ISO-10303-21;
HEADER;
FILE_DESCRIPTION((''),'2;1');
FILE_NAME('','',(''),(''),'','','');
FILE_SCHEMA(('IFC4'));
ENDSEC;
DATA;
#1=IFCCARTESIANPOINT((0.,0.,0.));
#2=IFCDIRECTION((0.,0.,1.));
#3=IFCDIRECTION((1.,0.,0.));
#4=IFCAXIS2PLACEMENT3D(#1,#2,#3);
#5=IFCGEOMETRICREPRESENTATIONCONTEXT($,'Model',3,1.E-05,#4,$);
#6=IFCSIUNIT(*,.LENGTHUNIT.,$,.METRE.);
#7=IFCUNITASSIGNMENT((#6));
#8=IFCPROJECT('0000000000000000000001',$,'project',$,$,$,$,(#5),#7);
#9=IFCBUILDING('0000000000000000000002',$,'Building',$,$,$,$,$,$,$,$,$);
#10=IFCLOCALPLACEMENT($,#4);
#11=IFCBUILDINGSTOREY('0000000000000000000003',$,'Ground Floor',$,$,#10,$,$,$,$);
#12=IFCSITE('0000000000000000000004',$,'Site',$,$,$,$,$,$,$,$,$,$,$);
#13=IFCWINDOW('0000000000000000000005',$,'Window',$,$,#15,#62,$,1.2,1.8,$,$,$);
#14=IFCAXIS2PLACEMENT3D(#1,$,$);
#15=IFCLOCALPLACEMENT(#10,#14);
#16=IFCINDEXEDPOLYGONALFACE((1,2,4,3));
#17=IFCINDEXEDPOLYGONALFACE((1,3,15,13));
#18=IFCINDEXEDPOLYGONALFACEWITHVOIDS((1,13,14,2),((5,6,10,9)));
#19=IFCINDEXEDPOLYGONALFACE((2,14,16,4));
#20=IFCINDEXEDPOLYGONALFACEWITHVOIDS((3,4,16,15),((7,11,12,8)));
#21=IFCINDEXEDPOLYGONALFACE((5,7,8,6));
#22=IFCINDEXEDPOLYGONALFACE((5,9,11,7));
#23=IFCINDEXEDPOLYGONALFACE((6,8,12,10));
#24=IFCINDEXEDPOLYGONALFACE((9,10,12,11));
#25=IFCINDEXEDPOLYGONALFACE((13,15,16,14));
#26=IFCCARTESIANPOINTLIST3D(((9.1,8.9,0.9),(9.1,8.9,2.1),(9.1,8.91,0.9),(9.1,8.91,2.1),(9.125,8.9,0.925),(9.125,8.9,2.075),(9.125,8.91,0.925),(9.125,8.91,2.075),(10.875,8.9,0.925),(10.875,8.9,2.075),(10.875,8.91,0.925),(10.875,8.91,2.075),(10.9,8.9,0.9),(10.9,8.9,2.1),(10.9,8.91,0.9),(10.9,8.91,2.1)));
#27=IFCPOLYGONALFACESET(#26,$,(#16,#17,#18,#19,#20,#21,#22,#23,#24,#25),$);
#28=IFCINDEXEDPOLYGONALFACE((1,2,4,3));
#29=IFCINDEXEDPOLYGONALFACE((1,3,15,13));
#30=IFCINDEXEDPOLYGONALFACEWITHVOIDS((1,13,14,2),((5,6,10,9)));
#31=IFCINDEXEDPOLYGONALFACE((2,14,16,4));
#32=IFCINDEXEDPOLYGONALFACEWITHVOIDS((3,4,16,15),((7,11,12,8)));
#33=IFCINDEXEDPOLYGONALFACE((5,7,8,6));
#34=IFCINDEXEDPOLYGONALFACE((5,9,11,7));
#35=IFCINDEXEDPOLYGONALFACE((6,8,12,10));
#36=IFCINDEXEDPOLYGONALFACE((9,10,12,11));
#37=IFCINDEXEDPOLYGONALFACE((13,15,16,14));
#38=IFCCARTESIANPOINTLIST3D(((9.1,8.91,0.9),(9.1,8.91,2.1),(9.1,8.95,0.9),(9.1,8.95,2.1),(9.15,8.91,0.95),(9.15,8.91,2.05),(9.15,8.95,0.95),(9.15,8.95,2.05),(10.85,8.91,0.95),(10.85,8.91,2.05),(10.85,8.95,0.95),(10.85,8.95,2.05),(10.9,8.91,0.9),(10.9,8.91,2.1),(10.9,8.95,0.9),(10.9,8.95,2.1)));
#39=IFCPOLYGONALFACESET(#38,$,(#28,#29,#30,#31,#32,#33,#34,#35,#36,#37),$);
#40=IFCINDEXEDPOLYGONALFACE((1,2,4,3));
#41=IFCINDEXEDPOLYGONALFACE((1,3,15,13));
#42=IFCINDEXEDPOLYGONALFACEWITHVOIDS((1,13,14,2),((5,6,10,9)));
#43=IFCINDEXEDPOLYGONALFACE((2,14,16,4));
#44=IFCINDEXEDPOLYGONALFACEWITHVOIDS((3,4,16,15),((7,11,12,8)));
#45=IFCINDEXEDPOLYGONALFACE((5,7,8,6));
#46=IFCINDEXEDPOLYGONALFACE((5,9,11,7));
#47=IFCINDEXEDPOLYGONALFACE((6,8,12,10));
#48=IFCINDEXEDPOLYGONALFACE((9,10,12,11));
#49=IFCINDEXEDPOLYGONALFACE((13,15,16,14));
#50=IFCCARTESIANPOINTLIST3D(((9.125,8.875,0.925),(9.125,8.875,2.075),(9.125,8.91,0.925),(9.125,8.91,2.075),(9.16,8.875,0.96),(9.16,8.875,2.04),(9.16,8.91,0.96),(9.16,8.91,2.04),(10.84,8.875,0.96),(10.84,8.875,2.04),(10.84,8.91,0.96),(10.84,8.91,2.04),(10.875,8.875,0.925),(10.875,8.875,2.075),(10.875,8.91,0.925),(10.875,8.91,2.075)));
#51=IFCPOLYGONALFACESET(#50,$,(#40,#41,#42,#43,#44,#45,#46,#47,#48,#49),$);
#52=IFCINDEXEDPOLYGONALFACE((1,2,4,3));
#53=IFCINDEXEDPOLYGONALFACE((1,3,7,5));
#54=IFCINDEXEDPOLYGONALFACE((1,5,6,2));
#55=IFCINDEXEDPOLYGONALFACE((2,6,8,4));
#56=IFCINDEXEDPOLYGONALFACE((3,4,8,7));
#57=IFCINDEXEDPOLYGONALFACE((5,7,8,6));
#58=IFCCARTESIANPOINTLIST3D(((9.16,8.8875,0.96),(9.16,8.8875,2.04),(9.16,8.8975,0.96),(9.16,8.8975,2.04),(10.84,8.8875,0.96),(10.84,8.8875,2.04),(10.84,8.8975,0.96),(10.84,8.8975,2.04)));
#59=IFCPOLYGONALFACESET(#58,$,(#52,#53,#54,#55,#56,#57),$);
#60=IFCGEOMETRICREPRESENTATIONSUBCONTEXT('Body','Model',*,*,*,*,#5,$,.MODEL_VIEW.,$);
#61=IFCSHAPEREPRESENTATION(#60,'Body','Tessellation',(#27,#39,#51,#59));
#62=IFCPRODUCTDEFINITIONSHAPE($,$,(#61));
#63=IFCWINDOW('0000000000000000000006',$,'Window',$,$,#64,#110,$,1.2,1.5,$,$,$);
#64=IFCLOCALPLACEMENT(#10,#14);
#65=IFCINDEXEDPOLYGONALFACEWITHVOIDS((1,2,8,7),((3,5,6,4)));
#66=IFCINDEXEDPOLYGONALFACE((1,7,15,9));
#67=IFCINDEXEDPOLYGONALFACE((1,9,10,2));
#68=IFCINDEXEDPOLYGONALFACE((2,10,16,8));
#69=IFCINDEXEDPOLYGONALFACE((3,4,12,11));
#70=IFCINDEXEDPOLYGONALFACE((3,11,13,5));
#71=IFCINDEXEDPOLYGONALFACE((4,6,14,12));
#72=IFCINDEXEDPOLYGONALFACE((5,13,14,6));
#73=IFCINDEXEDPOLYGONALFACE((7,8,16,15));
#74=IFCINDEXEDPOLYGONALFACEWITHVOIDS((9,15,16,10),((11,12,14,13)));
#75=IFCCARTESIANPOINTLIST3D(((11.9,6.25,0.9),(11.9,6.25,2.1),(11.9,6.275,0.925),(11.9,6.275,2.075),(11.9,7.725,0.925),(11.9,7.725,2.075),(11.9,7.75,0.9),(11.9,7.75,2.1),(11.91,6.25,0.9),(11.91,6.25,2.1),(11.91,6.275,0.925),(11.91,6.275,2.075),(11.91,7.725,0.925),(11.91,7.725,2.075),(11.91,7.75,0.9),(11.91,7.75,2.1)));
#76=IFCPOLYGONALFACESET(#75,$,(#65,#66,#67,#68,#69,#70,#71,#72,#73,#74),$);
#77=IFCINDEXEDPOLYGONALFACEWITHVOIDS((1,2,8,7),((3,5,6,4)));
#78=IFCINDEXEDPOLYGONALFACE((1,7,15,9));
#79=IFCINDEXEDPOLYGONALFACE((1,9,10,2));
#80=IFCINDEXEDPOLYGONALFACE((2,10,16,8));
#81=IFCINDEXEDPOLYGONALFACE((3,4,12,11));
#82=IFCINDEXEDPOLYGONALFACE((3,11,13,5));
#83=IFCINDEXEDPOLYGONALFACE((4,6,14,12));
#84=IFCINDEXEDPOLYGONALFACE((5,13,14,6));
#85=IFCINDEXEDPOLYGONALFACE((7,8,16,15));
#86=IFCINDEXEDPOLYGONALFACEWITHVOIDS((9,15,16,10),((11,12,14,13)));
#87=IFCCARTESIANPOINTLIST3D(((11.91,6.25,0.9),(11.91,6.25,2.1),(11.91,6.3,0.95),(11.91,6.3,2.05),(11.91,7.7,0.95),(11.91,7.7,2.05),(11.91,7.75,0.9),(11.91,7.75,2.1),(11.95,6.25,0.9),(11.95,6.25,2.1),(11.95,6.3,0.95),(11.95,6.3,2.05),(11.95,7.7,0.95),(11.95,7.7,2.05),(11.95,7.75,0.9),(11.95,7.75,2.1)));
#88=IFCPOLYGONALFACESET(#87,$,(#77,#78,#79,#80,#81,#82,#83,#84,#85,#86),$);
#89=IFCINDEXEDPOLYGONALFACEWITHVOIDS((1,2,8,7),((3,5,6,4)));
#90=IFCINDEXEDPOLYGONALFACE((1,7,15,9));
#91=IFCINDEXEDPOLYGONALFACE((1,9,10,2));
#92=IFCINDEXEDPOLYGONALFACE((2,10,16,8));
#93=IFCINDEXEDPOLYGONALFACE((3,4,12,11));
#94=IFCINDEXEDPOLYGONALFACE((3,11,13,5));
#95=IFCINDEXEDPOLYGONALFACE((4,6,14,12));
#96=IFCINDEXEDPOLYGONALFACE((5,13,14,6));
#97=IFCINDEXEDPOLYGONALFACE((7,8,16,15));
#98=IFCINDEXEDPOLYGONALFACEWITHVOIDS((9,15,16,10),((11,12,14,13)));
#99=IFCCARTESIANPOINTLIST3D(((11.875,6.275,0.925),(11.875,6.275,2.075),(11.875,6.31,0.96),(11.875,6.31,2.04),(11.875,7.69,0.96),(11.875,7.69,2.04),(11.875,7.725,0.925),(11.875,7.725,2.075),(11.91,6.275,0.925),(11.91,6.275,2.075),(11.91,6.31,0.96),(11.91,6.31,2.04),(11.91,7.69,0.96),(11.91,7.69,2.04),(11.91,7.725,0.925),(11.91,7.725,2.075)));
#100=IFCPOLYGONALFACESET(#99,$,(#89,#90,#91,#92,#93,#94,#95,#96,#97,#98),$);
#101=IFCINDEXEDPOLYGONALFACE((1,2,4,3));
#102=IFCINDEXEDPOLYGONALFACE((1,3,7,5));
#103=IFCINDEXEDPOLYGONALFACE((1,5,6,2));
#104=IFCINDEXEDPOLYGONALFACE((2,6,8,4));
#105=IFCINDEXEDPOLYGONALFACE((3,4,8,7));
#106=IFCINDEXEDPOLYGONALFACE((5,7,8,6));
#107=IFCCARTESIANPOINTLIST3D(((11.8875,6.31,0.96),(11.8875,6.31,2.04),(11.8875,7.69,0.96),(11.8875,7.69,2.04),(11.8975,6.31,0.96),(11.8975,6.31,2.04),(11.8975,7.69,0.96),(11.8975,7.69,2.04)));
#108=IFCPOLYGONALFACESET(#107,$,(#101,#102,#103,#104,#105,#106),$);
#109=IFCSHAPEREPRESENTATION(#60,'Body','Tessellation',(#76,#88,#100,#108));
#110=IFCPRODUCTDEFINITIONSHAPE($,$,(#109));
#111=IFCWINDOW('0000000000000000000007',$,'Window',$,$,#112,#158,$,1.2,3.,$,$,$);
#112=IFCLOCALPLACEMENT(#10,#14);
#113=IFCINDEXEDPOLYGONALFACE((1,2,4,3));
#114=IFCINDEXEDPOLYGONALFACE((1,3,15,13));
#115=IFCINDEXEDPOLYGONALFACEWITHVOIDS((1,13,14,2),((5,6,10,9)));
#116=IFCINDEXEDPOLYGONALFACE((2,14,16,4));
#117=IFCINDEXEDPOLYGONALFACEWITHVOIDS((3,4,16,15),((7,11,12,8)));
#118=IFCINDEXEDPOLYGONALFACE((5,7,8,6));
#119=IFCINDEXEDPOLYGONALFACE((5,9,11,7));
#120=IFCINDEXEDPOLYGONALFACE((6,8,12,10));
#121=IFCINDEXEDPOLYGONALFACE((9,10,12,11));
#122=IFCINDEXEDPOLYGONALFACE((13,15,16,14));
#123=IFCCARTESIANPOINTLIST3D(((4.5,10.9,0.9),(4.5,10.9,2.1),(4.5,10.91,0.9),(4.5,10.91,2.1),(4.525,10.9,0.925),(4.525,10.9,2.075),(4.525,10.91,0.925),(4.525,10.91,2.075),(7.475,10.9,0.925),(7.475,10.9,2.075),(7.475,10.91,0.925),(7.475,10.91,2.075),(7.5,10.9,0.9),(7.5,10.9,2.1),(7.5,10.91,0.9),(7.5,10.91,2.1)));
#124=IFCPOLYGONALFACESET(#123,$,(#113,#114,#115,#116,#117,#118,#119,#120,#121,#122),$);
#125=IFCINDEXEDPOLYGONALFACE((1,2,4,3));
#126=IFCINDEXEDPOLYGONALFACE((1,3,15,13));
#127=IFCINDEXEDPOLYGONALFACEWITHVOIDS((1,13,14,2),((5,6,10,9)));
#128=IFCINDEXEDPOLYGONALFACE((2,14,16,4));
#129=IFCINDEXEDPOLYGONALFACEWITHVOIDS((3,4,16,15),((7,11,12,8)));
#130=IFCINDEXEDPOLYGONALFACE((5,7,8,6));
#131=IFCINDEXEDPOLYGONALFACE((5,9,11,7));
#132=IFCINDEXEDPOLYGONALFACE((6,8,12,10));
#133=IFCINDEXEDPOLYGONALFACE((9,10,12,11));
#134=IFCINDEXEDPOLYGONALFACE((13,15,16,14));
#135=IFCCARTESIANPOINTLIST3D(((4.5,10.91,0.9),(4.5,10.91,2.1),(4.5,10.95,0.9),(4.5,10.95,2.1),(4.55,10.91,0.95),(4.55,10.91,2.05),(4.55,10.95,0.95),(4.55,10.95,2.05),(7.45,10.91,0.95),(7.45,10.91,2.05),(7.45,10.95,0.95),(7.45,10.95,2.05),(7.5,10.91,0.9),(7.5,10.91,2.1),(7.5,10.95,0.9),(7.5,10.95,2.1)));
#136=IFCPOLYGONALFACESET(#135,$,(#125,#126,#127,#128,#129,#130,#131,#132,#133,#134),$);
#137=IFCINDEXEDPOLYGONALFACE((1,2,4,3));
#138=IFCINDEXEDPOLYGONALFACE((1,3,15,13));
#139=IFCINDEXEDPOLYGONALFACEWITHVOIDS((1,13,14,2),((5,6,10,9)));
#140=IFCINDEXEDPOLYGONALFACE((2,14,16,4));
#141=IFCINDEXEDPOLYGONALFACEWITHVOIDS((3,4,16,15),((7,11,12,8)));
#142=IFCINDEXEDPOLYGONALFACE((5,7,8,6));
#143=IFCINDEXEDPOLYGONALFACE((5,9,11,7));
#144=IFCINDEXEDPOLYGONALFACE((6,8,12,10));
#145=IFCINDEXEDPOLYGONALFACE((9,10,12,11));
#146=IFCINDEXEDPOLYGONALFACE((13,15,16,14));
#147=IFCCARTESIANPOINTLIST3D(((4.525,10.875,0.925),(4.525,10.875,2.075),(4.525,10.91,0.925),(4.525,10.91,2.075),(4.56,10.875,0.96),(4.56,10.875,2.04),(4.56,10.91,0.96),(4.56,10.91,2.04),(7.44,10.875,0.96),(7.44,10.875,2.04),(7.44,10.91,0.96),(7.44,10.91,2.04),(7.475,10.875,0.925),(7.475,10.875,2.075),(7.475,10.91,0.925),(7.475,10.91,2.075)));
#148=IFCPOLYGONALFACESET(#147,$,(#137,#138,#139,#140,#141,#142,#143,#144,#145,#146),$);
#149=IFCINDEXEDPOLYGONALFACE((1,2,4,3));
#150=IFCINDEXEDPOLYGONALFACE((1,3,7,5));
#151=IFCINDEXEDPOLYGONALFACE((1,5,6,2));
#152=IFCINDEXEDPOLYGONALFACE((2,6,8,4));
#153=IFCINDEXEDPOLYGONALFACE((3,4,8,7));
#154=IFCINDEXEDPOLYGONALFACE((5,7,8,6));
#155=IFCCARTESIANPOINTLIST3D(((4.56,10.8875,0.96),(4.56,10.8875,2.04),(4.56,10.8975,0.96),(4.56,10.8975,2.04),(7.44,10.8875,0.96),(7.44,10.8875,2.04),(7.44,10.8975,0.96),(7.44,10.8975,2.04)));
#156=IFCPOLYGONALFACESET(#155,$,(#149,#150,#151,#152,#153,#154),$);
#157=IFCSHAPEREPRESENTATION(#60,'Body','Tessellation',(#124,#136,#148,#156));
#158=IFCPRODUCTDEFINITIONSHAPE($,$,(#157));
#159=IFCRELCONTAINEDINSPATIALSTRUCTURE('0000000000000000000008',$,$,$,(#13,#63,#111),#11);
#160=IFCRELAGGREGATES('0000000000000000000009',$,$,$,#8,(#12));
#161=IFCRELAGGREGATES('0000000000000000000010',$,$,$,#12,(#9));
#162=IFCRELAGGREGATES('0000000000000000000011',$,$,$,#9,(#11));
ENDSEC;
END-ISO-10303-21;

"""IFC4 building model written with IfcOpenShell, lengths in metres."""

from ifc_helpers import new_model, si_unit, frame, origin_with_axes, place, context, subcontext, project, spatial, line, indexed_curve, outline, extrude, element, save


model = new_model("IFC4")

# Units and contexts
model_context = context("Model", 3, precision=1e-05, world=origin_with_axes())
body_context = subcontext(model_context, "Body", "Model", "MODEL_VIEW")
ifc_project = project(units=[si_unit("LENGTHUNIT", "METRE")], contexts=[model_context])

# Site, building, storey
site = spatial("IfcSite", under=ifc_project, Name="Site")
building = spatial("IfcBuilding", under=site, Name="Building")
storey_placement = place(None, origin_with_axes())
storey = spatial("IfcBuildingStorey", under=building, at=storey_placement, Name="Ground Floor")

# Windows
window_1_placement = place(storey_placement, frame((10.9, 9.0, 0.9), z_axis=(0.0, 0.0, 1.0), x_axis=(-1.0, 0.0, 0.0)))
element("IfcWindow", 1, at=window_1_placement, inside=storey, Name="Window", OverallHeight=1.2, OverallWidth=1.8, context=body_context, shape_type="SweptSolid", body=[
    extrude(outline(indexed_curve([(0.0, 0.0), (1.8, 0.0), (1.8, 1.2), (0.0, 1.2)], segments=[line(1, 2, 3, 4, 1)]), holes=[indexed_curve([(0.025, 0.025), (1.775, 0.025), (1.775, 1.175), (0.025, 1.175)], segments=[line(1, 2, 3, 4, 1)])]), frame((0.0, 0.09, 0.0), z_axis=(0.0, -1.0, 0.0), x_axis=(1.0, 0.0, 0.0)), (0.0, 0.0, -1.0), 0.01),
    extrude(outline(indexed_curve([(0.0, 0.0), (1.8, 0.0), (1.8, 1.2), (0.0, 1.2)], segments=[line(1, 2, 3, 4, 1)]), holes=[indexed_curve([(0.05, 0.05), (1.75, 0.05), (1.75, 1.15), (0.05, 1.15)], segments=[line(1, 2, 3, 4, 1)])]), frame((0.0, 0.05, 0.0), z_axis=(0.0, -1.0, 0.0), x_axis=(1.0, 0.0, 0.0)), (0.0, 0.0, -1.0), 0.04),
    extrude(outline(indexed_curve([(0.0, 0.0), (1.75, 0.0), (1.75, 1.15), (0.0, 1.15)], segments=[line(1, 2, 3, 4, 1)]), holes=[indexed_curve([(0.035, 0.035), (1.715, 0.035), (1.715, 1.115), (0.035, 1.115)], segments=[line(1, 2, 3, 4, 1)])]), frame((0.025, 0.09, 0.025), z_axis=(0.0, -1.0, 0.0), x_axis=(1.0, 0.0, 0.0)), (0.0, 0.0, -1.0), 0.035),
    extrude(outline(indexed_curve([(0.035, 0.035), (1.715, 0.035), (1.715, 1.115), (0.035, 1.115)], segments=[line(1, 2, 3, 4, 1)])), frame((0.025, 0.1025, 0.025), z_axis=(0.0, -1.0, 0.0), x_axis=(1.0, 0.0, 0.0)), (0.0, 0.0, -1.0), 0.01),
])
window_2_placement = place(storey_placement, frame((12.0, 6.25, 0.9), z_axis=(0.0, 0.0, 1.0), x_axis=(0.0, 1.0, 0.0)))
element("IfcWindow", 2, at=window_2_placement, inside=storey, Name="Window", OverallHeight=1.2, OverallWidth=1.5, context=body_context, shape_type="SweptSolid", body=[
    extrude(outline(indexed_curve([(0.0, 0.0), (1.5, 0.0), (1.5, 1.2), (0.0, 1.2)], segments=[line(1, 2, 3, 4, 1)]), holes=[indexed_curve([(0.025, 0.025), (1.475, 0.025), (1.475, 1.175), (0.025, 1.175)], segments=[line(1, 2, 3, 4, 1)])]), frame((0.0, 0.09, 0.0), z_axis=(0.0, -1.0, 0.0), x_axis=(1.0, 0.0, 0.0)), (0.0, 0.0, -1.0), 0.01),
    extrude(outline(indexed_curve([(0.0, 0.0), (1.5, 0.0), (1.5, 1.2), (0.0, 1.2)], segments=[line(1, 2, 3, 4, 1)]), holes=[indexed_curve([(0.05, 0.05), (1.45, 0.05), (1.45, 1.15), (0.05, 1.15)], segments=[line(1, 2, 3, 4, 1)])]), frame((0.0, 0.05, 0.0), z_axis=(0.0, -1.0, 0.0), x_axis=(1.0, 0.0, 0.0)), (0.0, 0.0, -1.0), 0.04),
    extrude(outline(indexed_curve([(0.0, 0.0), (1.45, 0.0), (1.45, 1.15), (0.0, 1.15)], segments=[line(1, 2, 3, 4, 1)]), holes=[indexed_curve([(0.035, 0.035), (1.415, 0.035), (1.415, 1.115), (0.035, 1.115)], segments=[line(1, 2, 3, 4, 1)])]), frame((0.025, 0.09, 0.025), z_axis=(0.0, -1.0, 0.0), x_axis=(1.0, 0.0, 0.0)), (0.0, 0.0, -1.0), 0.035),
    extrude(outline(indexed_curve([(0.035, 0.035), (1.415, 0.035), (1.415, 1.115), (0.035, 1.115)], segments=[line(1, 2, 3, 4, 1)])), frame((0.025, 0.1025, 0.025), z_axis=(0.0, -1.0, 0.0), x_axis=(1.0, 0.0, 0.0)), (0.0, 0.0, -1.0), 0.01),
])
window_3_placement = place(storey_placement, frame((7.5, 11.0, 0.9), z_axis=(0.0, 0.0, 1.0), x_axis=(-1.0, 0.0, 0.0)))
element("IfcWindow", 3, at=window_3_placement, inside=storey, Name="Window", OverallHeight=1.2, OverallWidth=3.0, context=body_context, shape_type="SweptSolid", body=[
    extrude(outline(indexed_curve([(0.0, 0.0), (3.0, 0.0), (3.0, 1.2), (0.0, 1.2)], segments=[line(1, 2, 3, 4, 1)]), holes=[indexed_curve([(0.025, 0.025), (2.975, 0.025), (2.975, 1.175), (0.025, 1.175)], segments=[line(1, 2, 3, 4, 1)])]), frame((0.0, 0.09, 0.0), z_axis=(0.0, -1.0, 0.0), x_axis=(1.0, 0.0, 0.0)), (0.0, 0.0, -1.0), 0.01),
    extrude(outline(indexed_curve([(0.0, 0.0), (3.0, 0.0), (3.0, 1.2), (0.0, 1.2)], segments=[line(1, 2, 3, 4, 1)]), holes=[indexed_curve([(0.05, 0.05), (2.95, 0.05), (2.95, 1.15), (0.05, 1.15)], segments=[line(1, 2, 3, 4, 1)])]), frame((0.0, 0.05, 0.0), z_axis=(0.0, -1.0, 0.0), x_axis=(1.0, 0.0, 0.0)), (0.0, 0.0, -1.0), 0.04),
    extrude(outline(indexed_curve([(0.0, 0.0), (2.95, 0.0), (2.95, 1.15), (0.0, 1.15)], segments=[line(1, 2, 3, 4, 1)]), holes=[indexed_curve([(0.035, 0.035), (2.915, 0.035), (2.915, 1.115), (0.035, 1.115)], segments=[line(1, 2, 3, 4, 1)])]), frame((0.025, 0.09, 0.025), z_axis=(0.0, -1.0, 0.0), x_axis=(1.0, 0.0, 0.0)), (0.0, 0.0, -1.0), 0.035),
    extrude(outline(indexed_curve([(0.035, 0.035), (2.915, 0.035), (2.915, 1.115), (0.035, 1.115)], segments=[line(1, 2, 3, 4, 1)])), frame((0.025, 0.1025, 0.025), z_axis=(0.0, -1.0, 0.0), x_axis=(1.0, 0.0, 0.0)), (0.0, 0.0, -1.0), 0.01),
])

save(model, "model.ifc")
